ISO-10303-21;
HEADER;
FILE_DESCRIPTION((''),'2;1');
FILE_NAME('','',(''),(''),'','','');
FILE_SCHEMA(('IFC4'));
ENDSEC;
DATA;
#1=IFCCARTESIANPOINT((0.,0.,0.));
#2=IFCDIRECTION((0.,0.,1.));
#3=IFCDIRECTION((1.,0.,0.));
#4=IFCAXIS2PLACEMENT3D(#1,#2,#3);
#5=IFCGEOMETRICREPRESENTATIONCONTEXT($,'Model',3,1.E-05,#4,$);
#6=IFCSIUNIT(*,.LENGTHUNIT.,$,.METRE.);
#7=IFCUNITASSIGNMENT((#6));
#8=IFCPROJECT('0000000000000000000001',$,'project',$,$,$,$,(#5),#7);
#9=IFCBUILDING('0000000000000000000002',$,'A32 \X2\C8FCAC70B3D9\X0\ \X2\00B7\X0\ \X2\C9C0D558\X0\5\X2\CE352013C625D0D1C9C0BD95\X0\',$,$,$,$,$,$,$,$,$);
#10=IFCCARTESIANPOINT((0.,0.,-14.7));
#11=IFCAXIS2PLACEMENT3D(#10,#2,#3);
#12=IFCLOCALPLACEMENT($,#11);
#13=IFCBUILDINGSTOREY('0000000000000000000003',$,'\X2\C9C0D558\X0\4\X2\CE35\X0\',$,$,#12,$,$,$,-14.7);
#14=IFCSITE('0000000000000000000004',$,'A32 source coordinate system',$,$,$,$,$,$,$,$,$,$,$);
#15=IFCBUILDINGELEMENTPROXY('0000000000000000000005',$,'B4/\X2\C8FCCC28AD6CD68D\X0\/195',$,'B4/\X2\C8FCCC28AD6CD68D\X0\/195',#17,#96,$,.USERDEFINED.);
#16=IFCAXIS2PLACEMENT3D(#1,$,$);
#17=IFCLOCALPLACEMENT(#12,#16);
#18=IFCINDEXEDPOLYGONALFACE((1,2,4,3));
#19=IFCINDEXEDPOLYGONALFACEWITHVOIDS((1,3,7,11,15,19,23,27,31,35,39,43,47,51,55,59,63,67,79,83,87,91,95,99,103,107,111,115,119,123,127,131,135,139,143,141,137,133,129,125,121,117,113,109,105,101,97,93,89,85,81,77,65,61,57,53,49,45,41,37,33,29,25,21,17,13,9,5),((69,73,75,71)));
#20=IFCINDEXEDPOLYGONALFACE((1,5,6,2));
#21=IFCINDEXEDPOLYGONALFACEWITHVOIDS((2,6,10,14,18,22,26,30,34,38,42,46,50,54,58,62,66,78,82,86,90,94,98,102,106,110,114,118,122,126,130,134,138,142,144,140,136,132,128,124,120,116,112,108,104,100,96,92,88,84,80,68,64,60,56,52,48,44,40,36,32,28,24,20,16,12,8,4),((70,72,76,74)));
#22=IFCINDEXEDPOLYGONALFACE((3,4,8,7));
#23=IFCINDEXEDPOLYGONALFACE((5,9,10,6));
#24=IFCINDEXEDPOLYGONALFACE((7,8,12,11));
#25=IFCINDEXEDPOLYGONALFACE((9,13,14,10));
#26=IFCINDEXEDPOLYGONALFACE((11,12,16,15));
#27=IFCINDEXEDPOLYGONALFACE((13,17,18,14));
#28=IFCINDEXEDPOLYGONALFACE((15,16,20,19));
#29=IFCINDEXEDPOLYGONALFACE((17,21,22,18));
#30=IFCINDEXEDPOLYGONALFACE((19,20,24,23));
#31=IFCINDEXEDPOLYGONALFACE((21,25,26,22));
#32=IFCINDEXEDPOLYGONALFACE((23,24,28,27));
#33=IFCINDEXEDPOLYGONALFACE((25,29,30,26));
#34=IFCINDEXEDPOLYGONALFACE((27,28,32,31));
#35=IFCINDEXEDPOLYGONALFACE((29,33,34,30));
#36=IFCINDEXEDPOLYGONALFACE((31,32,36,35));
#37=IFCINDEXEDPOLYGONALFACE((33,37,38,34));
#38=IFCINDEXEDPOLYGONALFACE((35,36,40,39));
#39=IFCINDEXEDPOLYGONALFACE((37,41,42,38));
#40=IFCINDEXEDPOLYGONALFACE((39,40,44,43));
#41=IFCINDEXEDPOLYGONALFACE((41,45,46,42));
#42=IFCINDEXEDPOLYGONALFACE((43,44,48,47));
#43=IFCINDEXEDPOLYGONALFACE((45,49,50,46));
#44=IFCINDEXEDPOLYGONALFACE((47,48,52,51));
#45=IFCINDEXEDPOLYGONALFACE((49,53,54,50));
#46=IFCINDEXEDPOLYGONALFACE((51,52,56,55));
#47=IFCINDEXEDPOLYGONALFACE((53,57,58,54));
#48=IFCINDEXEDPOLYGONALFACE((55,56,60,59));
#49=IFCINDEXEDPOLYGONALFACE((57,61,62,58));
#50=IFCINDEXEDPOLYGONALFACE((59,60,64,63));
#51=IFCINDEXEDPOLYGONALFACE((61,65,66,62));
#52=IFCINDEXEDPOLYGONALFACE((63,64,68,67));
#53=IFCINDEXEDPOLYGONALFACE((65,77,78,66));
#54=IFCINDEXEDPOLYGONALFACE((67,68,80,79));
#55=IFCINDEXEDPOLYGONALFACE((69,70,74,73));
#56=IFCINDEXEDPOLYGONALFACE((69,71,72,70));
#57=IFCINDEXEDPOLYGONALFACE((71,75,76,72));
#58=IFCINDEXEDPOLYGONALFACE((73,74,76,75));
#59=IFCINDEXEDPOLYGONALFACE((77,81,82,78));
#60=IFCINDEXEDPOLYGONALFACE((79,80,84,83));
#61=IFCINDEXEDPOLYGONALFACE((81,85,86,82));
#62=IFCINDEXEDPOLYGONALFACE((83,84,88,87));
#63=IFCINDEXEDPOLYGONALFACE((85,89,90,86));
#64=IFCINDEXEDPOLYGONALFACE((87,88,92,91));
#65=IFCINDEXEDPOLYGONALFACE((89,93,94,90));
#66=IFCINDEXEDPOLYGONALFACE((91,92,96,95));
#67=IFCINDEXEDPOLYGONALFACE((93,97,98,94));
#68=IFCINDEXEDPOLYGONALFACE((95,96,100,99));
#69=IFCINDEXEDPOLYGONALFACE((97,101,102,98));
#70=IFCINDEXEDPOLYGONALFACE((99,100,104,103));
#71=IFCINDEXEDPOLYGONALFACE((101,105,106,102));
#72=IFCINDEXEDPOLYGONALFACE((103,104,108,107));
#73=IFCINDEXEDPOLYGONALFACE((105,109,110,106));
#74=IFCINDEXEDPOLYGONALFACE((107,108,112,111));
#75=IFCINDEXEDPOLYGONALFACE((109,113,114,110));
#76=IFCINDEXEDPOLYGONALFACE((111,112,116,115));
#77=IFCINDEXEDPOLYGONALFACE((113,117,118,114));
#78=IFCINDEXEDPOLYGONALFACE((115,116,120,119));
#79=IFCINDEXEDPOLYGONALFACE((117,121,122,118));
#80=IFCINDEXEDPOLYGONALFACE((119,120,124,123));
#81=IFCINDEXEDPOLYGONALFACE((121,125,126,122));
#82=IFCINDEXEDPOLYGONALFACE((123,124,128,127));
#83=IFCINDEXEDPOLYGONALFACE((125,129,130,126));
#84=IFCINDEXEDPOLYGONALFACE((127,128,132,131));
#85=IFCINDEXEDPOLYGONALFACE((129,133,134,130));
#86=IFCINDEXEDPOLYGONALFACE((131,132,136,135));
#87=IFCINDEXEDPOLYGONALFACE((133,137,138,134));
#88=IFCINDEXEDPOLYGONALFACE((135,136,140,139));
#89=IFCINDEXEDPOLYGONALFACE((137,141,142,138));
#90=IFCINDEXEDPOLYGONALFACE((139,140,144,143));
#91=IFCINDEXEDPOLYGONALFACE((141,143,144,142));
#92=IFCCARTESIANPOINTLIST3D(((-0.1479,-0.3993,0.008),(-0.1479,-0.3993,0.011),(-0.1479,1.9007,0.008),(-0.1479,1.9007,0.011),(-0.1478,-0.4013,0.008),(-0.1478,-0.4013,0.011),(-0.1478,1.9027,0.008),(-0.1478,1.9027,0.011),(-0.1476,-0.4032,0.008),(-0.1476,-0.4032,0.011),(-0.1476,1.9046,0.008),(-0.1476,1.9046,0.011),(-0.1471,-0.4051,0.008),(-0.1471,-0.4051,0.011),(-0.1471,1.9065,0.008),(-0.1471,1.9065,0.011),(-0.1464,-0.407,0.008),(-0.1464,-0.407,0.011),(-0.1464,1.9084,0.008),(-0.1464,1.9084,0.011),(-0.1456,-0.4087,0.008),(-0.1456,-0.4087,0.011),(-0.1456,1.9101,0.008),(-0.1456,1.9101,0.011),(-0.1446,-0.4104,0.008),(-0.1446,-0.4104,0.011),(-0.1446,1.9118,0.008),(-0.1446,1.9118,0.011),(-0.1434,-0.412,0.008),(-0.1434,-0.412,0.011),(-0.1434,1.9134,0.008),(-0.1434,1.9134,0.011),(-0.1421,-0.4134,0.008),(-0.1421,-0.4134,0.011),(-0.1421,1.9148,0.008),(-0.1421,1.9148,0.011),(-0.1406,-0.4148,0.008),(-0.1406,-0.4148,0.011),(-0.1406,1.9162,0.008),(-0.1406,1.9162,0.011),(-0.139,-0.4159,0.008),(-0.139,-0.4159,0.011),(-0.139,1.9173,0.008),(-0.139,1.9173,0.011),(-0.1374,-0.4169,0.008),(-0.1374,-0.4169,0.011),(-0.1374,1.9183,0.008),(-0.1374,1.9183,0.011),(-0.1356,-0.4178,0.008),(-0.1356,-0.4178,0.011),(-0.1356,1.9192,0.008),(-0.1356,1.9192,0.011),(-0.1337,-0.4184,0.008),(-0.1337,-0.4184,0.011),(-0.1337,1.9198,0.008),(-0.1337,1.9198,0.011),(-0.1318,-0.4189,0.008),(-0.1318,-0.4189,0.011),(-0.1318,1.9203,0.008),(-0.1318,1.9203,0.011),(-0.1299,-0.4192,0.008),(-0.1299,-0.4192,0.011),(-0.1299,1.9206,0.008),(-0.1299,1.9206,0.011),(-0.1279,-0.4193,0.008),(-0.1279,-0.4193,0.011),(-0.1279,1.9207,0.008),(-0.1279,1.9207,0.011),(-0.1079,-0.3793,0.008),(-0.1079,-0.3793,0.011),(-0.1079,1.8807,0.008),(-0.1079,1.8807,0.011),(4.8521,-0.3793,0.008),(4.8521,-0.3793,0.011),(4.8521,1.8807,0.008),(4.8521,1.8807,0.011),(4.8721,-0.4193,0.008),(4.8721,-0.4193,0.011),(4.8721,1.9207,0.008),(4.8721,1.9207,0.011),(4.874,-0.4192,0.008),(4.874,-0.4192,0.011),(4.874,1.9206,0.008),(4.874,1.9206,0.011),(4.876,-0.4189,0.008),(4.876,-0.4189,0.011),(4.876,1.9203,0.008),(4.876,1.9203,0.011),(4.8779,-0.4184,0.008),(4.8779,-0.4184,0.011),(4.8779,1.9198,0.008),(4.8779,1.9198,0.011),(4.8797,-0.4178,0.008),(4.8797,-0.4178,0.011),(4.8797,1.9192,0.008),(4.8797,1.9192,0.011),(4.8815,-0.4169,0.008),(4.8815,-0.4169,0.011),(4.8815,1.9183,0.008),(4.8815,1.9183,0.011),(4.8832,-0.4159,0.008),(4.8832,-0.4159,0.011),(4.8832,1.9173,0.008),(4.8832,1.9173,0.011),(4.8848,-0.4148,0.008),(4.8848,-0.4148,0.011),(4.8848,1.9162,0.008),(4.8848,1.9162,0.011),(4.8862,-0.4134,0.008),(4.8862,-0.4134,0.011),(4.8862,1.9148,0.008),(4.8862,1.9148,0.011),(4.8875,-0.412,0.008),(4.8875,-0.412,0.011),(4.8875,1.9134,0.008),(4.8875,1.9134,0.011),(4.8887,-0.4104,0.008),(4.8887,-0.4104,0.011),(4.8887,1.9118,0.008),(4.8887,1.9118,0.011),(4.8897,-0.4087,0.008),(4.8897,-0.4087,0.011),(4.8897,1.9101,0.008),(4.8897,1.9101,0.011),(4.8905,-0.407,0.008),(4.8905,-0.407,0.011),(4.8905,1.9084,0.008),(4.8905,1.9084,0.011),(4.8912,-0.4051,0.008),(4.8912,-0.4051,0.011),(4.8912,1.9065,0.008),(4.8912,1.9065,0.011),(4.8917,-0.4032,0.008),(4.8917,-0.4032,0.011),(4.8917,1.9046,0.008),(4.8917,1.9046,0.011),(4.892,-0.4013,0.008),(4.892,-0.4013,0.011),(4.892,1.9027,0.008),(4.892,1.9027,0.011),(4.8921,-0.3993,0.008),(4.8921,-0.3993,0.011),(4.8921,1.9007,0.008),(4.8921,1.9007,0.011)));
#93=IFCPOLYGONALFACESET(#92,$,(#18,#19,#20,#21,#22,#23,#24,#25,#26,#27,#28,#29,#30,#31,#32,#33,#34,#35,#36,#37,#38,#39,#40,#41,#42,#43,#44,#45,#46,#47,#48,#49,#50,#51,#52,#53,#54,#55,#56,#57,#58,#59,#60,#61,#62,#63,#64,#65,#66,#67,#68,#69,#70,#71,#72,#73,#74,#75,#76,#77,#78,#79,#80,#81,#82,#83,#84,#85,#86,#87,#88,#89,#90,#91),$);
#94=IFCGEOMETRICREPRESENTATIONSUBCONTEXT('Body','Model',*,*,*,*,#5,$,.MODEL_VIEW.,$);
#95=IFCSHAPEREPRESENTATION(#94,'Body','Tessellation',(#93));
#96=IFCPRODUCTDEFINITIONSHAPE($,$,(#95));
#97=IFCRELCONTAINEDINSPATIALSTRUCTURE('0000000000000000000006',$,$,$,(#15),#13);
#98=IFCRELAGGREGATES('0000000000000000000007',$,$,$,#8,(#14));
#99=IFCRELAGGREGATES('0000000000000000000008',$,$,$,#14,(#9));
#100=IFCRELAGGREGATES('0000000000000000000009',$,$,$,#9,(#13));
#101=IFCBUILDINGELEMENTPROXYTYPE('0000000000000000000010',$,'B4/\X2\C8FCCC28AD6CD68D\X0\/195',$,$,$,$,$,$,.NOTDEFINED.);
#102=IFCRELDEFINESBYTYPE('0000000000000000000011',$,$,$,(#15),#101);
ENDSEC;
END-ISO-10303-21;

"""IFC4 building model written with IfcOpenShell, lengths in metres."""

from ifc_helpers import new_model, si_unit, frame, origin, origin_with_axes, place, context, subcontext, project, spatial, polyline, outline, extrude, source, transform, mapped, type_object, type_shapes, element, save


model = new_model("IFC4")

# Units and contexts
model_context = context("Model", 3, precision=1e-05, world=origin_with_axes())
body_context = subcontext(model_context, "Body", "Model", "MODEL_VIEW")
ifc_project = project(units=[si_unit("LENGTHUNIT", "METRE")], contexts=[model_context])

# Site, building, storey
site = spatial("IfcSite", under=ifc_project, Name="A32 source coordinate system")
building = spatial("IfcBuilding", under=site, Name="A32 주거동 · 지하5층–옥탑지붕")
storey_placement = place(None, frame((0.0, 0.0, -14.7), z_axis=(0.0, 0.0, 1.0), x_axis=(1.0, 0.0, 0.0)))
storey = spatial("IfcBuildingStorey", under=building, at=storey_placement, Name="지하4층", Elevation=-14.7)

# Building element proxy
building_element_proxy_type_1 = type_object("IfcBuildingElementProxyType", Name="B4/주차구획/195", PredefinedType="NOTDEFINED")
shared_shape_1 = source(origin(), body_context, "Body", "SweptSolid", [
    extrude(outline(polyline([(-0.1279, -0.4193), (-0.1299, -0.4192), (-0.1318, -0.4189), (-0.1337, -0.4184), (-0.1356, -0.4178), (-0.1374, -0.4169), (-0.139, -0.4159), (-0.1406, -0.4148), (-0.1421, -0.4134), (-0.1434, -0.412), (-0.1446, -0.4104), (-0.1456, -0.4087), (-0.1464, -0.407), (-0.1471, -0.4051), (-0.1476, -0.4032), (-0.1478, -0.4013), (-0.1479, -0.3993), (-0.1479, 1.9007), (-0.1478, 1.9027), (-0.1476, 1.9046), (-0.1471, 1.9065), (-0.1464, 1.9084), (-0.1456, 1.9101), (-0.1446, 1.9118), (-0.1434, 1.9134), (-0.1421, 1.9148), (-0.1406, 1.9162), (-0.139, 1.9173), (-0.1374, 1.9183), (-0.1356, 1.9192), (-0.1337, 1.9198), (-0.1318, 1.9203), (-0.1299, 1.9206), (-0.1279, 1.9207), (4.8721, 1.9207), (4.874, 1.9206), (4.876, 1.9203), (4.8779, 1.9198), (4.8797, 1.9192), (4.8815, 1.9183), (4.8832, 1.9173), (4.8848, 1.9162), (4.8862, 1.9148), (4.8875, 1.9134), (4.8887, 1.9118), (4.8897, 1.9101), (4.8905, 1.9084), (4.8912, 1.9065), (4.8917, 1.9046), (4.892, 1.9027), (4.8921, 1.9007), (4.8921, -0.3993), (4.892, -0.4013), (4.8917, -0.4032), (4.8912, -0.4051), (4.8905, -0.407), (4.8897, -0.4087), (4.8887, -0.4104), (4.8875, -0.412), (4.8862, -0.4134), (4.8848, -0.4148), (4.8832, -0.4159), (4.8815, -0.4169), (4.8797, -0.4178), (4.8779, -0.4184), (4.876, -0.4189), (4.874, -0.4192), (4.8721, -0.4193), (-0.1279, -0.4193)]), holes=[polyline([(-0.1079, -0.3793), (4.8521, -0.3793), (4.8521, 1.8807), (-0.1079, 1.8807), (-0.1079, -0.3793)])]), frame((0.0, 0.0, 0.008)), (0.0, 0.0, 1.0), 0.003),
])
type_shapes(building_element_proxy_type_1, [shared_shape_1])
proxy_1_placement = place(storey_placement, origin_with_axes())
element("IfcBuildingElementProxy", 1, at=proxy_1_placement, inside=storey, type_object=building_element_proxy_type_1, Name="B4/주차구획/195", ObjectType="B4/주차구획/195", PredefinedType="USERDEFINED", context=body_context, shape_type="MappedRepresentation", body=[
    mapped(shared_shape_1, transform((0.0, 0.0, 0.0), scale=1.0)),
])

save(model, "model.ifc")
